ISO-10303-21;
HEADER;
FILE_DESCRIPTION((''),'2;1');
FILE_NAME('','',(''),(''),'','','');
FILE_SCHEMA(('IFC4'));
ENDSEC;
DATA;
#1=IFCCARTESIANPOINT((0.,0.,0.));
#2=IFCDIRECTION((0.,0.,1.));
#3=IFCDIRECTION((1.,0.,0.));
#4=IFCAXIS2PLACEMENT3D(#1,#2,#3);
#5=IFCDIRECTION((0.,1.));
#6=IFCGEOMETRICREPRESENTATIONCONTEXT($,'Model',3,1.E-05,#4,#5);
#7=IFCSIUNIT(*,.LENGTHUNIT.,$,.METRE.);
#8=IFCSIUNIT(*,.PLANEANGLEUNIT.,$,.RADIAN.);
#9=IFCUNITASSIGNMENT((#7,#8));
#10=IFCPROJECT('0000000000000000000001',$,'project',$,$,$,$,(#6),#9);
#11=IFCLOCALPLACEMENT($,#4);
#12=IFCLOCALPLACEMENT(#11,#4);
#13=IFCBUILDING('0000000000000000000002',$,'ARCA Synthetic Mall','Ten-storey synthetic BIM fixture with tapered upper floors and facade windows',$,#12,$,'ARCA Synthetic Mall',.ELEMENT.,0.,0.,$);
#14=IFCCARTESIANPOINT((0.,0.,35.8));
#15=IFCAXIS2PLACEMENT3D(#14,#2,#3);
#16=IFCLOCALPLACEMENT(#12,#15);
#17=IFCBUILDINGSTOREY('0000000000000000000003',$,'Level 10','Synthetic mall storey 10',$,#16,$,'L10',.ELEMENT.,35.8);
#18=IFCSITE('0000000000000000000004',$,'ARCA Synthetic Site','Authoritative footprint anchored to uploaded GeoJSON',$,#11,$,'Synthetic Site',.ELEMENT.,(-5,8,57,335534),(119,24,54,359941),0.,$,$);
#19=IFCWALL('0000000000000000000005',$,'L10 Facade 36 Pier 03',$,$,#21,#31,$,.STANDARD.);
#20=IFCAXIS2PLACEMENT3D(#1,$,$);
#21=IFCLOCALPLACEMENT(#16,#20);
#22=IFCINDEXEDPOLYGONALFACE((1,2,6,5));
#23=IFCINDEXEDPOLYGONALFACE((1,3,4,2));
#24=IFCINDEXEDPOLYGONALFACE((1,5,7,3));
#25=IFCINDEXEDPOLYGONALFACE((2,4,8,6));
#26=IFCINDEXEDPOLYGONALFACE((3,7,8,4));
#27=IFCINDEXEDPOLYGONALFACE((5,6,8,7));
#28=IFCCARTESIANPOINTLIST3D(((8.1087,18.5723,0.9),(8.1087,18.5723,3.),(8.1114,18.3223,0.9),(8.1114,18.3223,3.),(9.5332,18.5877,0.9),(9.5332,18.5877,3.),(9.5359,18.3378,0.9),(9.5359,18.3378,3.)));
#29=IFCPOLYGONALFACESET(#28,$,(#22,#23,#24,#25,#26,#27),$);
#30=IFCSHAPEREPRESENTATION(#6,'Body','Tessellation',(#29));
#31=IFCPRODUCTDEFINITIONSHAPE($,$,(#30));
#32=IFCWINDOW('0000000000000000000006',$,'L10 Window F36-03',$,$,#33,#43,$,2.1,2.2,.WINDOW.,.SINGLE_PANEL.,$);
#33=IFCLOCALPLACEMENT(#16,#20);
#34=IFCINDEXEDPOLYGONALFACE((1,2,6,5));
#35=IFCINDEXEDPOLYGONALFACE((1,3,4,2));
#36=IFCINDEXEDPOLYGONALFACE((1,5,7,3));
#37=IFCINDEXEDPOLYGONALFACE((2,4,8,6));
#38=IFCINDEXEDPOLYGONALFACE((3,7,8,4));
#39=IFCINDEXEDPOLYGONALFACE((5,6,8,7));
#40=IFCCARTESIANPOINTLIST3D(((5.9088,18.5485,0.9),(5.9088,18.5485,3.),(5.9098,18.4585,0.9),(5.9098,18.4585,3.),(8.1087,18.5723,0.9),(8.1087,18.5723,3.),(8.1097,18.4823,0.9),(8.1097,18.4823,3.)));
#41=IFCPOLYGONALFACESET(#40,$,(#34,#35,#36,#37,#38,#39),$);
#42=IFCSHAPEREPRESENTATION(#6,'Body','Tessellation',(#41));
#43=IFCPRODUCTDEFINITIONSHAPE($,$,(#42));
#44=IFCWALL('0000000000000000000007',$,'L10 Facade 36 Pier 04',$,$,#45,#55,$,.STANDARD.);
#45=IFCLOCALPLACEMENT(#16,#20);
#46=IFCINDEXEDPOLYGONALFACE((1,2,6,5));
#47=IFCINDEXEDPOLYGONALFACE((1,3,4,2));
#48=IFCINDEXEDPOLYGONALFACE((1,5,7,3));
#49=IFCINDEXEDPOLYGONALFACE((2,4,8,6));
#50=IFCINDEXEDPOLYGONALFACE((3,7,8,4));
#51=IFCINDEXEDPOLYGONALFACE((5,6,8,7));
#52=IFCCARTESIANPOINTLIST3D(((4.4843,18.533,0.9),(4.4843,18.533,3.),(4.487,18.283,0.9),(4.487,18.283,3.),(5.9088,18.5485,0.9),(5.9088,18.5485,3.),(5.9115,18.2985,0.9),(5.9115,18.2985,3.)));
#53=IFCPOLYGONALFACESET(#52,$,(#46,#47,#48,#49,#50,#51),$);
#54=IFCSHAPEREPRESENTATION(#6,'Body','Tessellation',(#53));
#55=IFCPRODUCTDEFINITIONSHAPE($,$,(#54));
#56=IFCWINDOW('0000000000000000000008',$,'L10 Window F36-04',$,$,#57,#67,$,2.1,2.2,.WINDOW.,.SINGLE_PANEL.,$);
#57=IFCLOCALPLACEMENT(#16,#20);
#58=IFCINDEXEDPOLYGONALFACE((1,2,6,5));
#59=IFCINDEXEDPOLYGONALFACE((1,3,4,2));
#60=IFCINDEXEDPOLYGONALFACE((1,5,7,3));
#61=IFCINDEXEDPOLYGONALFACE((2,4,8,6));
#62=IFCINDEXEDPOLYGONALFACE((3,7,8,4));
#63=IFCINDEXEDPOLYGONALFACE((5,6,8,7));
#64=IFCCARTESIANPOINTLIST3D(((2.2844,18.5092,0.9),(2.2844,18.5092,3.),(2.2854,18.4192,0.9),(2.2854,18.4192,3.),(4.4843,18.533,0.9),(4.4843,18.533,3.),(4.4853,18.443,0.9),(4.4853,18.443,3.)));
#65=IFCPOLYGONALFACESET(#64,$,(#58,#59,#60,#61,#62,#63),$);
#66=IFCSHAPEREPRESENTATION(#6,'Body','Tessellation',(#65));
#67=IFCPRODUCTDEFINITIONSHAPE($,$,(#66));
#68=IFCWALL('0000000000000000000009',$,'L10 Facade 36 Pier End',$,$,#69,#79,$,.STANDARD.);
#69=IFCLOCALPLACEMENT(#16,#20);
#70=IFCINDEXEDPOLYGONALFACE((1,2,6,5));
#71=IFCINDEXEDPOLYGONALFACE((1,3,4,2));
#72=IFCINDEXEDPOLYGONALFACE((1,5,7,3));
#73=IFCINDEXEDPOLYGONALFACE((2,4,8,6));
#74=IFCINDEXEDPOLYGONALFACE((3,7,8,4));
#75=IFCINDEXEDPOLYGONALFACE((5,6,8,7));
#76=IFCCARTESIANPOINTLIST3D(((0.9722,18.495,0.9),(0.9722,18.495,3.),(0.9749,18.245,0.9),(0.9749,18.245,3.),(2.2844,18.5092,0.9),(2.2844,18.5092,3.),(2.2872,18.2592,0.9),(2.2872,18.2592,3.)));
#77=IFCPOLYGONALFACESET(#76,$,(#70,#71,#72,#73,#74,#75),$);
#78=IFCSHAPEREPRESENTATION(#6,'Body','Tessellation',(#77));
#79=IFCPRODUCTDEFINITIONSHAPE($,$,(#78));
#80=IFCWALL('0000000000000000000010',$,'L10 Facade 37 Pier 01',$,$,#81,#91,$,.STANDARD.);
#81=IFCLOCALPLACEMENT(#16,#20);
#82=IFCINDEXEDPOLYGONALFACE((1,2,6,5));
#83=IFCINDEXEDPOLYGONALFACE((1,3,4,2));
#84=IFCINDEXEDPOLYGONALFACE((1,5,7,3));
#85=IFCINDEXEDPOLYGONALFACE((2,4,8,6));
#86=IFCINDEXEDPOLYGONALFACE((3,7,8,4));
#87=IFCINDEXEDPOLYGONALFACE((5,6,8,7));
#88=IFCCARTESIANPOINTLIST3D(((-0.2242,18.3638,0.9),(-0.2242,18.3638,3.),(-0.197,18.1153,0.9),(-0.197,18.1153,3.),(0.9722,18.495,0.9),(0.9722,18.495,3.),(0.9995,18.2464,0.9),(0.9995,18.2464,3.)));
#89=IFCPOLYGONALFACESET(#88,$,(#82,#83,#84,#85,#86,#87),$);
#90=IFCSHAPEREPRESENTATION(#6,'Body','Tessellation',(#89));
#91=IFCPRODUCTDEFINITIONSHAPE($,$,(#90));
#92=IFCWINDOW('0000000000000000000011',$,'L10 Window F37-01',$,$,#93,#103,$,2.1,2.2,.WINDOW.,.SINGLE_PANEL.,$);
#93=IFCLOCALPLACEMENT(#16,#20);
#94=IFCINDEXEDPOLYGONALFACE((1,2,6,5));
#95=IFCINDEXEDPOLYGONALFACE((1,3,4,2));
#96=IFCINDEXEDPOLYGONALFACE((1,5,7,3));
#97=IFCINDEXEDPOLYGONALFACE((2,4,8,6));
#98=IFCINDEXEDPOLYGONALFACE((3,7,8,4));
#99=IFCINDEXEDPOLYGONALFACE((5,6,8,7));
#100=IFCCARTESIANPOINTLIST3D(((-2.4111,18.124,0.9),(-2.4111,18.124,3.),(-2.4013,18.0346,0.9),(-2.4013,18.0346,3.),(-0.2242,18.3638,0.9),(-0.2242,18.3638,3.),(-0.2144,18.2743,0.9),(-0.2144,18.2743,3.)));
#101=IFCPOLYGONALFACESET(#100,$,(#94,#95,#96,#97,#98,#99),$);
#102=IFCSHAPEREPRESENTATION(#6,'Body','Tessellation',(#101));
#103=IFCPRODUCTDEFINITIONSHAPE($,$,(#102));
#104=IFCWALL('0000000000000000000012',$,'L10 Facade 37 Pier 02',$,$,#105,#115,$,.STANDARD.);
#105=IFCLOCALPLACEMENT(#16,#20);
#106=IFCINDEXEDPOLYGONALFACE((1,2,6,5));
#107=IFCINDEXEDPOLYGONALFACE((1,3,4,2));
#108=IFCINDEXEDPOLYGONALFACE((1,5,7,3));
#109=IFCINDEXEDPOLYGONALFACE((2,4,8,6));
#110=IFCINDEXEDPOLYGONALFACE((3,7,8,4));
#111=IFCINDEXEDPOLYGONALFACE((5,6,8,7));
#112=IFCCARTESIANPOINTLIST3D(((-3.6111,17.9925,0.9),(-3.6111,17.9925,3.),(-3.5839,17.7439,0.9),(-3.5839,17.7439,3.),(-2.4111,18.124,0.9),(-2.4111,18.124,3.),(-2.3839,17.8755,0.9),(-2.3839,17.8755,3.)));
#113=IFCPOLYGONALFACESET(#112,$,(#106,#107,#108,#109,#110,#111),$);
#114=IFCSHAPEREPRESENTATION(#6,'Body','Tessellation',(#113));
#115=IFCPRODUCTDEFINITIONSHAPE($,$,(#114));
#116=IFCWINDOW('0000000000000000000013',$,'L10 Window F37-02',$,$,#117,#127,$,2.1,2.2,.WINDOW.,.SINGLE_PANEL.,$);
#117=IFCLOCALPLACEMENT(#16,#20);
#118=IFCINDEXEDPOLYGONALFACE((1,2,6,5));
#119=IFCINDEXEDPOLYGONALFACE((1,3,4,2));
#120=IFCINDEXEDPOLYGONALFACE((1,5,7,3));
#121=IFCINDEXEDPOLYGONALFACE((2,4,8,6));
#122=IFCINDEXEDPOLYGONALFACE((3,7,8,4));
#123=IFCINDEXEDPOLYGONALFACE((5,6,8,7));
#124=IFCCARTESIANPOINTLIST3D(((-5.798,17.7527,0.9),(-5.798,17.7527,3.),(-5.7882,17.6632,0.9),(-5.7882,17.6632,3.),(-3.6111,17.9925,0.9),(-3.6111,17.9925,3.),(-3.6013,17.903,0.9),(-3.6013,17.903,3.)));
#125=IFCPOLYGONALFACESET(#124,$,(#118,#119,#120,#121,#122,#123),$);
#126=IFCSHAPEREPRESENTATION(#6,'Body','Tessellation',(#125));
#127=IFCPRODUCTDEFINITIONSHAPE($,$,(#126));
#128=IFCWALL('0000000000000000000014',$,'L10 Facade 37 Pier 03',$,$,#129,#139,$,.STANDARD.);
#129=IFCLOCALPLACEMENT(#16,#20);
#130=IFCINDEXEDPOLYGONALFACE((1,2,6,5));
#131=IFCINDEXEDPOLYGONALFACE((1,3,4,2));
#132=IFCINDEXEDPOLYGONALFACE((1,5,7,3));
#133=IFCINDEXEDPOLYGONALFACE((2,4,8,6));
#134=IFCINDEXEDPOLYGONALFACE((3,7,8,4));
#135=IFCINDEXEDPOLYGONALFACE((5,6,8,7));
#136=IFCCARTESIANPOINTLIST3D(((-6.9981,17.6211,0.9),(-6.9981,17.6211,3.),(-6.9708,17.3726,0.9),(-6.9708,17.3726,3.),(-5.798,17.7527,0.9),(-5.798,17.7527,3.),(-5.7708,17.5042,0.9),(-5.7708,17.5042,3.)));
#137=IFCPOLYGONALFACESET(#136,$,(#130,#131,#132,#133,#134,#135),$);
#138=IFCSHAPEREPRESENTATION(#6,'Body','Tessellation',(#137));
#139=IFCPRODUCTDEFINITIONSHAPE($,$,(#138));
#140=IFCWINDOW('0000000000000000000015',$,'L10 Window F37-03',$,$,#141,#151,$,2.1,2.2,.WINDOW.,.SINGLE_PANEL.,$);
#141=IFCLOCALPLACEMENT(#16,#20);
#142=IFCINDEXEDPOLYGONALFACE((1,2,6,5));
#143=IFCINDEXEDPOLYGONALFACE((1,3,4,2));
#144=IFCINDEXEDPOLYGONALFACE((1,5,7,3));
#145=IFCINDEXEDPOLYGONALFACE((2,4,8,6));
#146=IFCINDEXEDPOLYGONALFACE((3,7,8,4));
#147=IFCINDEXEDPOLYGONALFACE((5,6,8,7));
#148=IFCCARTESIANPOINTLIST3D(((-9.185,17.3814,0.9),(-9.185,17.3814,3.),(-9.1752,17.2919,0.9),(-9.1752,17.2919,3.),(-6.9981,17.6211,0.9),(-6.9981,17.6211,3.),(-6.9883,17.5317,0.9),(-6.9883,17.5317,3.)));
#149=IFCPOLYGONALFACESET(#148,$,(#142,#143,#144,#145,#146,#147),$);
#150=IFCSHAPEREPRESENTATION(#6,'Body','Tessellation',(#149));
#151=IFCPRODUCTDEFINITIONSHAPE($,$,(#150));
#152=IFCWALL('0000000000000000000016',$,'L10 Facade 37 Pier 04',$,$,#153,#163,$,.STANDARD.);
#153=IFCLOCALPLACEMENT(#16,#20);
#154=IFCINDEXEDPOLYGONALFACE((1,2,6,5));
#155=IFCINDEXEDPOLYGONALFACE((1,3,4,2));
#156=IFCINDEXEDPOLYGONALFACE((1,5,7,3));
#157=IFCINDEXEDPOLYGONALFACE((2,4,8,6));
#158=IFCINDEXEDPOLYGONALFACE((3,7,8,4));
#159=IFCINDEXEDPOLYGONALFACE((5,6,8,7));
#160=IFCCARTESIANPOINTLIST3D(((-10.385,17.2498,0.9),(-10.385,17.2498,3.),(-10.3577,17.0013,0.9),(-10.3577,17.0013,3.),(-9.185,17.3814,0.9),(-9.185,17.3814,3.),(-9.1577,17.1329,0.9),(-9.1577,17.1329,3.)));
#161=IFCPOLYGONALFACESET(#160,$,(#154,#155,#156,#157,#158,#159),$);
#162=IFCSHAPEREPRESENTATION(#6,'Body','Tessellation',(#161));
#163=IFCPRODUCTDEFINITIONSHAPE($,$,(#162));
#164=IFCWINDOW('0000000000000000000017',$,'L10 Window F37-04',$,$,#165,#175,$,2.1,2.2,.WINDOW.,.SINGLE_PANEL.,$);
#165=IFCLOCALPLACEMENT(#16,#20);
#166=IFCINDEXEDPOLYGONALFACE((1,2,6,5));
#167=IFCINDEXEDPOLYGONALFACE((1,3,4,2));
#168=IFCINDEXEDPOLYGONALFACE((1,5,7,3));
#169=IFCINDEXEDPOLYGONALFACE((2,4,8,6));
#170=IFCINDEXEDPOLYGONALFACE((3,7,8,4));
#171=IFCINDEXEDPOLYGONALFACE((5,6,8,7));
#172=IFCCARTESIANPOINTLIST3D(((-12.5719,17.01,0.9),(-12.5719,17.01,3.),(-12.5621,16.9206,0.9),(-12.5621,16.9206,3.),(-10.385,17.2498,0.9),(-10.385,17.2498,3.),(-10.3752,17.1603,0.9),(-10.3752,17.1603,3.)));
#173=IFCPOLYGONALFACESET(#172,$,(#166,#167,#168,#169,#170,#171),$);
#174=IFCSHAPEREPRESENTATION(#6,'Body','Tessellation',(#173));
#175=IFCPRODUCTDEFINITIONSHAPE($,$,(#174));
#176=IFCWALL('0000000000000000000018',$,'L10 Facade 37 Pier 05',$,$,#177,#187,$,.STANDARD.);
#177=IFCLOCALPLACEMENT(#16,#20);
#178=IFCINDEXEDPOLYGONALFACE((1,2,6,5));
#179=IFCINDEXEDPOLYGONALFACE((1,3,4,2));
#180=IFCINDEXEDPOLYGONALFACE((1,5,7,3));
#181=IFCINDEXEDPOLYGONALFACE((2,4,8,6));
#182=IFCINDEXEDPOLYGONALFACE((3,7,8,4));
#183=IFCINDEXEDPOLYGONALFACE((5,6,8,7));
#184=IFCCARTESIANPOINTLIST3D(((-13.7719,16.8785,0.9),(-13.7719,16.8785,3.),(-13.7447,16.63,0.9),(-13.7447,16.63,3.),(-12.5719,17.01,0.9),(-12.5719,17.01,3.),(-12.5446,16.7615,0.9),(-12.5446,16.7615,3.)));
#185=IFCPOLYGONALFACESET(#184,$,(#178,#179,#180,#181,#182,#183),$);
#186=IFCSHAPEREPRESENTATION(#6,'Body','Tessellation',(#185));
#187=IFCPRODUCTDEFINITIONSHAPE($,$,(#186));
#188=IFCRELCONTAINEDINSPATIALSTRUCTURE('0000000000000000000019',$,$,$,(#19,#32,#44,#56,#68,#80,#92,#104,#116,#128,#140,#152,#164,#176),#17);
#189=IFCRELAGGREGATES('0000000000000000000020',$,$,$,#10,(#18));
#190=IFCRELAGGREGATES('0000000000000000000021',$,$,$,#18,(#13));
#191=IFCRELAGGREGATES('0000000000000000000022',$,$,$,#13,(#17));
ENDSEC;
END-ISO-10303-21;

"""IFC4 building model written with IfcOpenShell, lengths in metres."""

from ifc_helpers import new_model, si_unit, direction, frame, origin_with_axes, place, context, project, spatial, polyline, outline, extrude, element, save


model = new_model("IFC4")

# Units and contexts
model_context = context("Model", 3, precision=1e-05, world=origin_with_axes(), true_north=direction((0.0, 1.0)))
ifc_project = project(units=[si_unit("LENGTHUNIT", "METRE"), si_unit("PLANEANGLEUNIT", "RADIAN")], contexts=[model_context])

# Site, building, storey
site_placement = place(None, origin_with_axes())
site = spatial("IfcSite", under=ifc_project, at=site_placement, Name="ARCA Synthetic Site", Description="Authoritative footprint anchored to uploaded GeoJSON", LongName="Synthetic Site", CompositionType="ELEMENT", RefLatitude=(-5, 8, 57, 335534), RefLongitude=(119, 24, 54, 359941), RefElevation=0.0)
building_placement = place(site_placement, origin_with_axes())
building = spatial("IfcBuilding", under=site, at=building_placement, Name="ARCA Synthetic Mall", Description="Ten-storey synthetic BIM fixture with tapered upper floors and facade windows", LongName="ARCA Synthetic Mall", CompositionType="ELEMENT", ElevationOfRefHeight=0.0, ElevationOfTerrain=0.0)
storey_placement = place(building_placement, frame((0.0, 0.0, 35.8), z_axis=(0.0, 0.0, 1.0), x_axis=(1.0, 0.0, 0.0)))
storey = spatial("IfcBuildingStorey", under=building, at=storey_placement, Name="Level 10", Description="Synthetic mall storey 10", LongName="L10", CompositionType="ELEMENT", Elevation=35.8)

# Wall
wall_1_placement = place(storey_placement, frame((0.0, 0.0, 0.9), z_axis=(0.0, 0.0, 1.0), x_axis=(1.0, 0.0, 0.0)))
element("IfcWall", 1, at=wall_1_placement, inside=storey, Name="L10 Facade 36 Pier 03", PredefinedType="STANDARD", context=model_context, shape_type="SweptSolid", body=[
    extrude(outline(polyline([(9.5332, 18.5877), (8.1087, 18.5723), (8.1114, 18.3223), (9.5359, 18.3378), (9.5332, 18.5877)])), origin_with_axes(), (0.0, 0.0, 1.0), 2.1),
])

# Window
window_1_placement = place(storey_placement, frame((0.0, 0.0, 0.9), z_axis=(0.0, 0.0, 1.0), x_axis=(1.0, 0.0, 0.0)))
element("IfcWindow", 2, at=window_1_placement, inside=storey, Name="L10 Window F36-03", OverallHeight=2.1, OverallWidth=2.2, PartitioningType="SINGLE_PANEL", PredefinedType="WINDOW", context=model_context, shape_type="SweptSolid", body=[
    extrude(outline(polyline([(8.1087, 18.5723), (5.9088, 18.5485), (5.9098, 18.4585), (8.1097, 18.4823), (8.1087, 18.5723)])), origin_with_axes(), (0.0, 0.0, 1.0), 2.1),
])

# Wall
wall_2_placement = place(storey_placement, frame((0.0, 0.0, 0.9), z_axis=(0.0, 0.0, 1.0), x_axis=(1.0, 0.0, 0.0)))
element("IfcWall", 3, at=wall_2_placement, inside=storey, Name="L10 Facade 36 Pier 04", PredefinedType="STANDARD", context=model_context, shape_type="SweptSolid", body=[
    extrude(outline(polyline([(5.9088, 18.5485), (4.4843, 18.533), (4.487, 18.283), (5.9115, 18.2985), (5.9088, 18.5485)])), origin_with_axes(), (0.0, 0.0, 1.0), 2.1),
])

# Window
window_2_placement = place(storey_placement, frame((0.0, 0.0, 0.9), z_axis=(0.0, 0.0, 1.0), x_axis=(1.0, 0.0, 0.0)))
element("IfcWindow", 4, at=window_2_placement, inside=storey, Name="L10 Window F36-04", OverallHeight=2.1, OverallWidth=2.2, PartitioningType="SINGLE_PANEL", PredefinedType="WINDOW", context=model_context, shape_type="SweptSolid", body=[
    extrude(outline(polyline([(4.4843, 18.533), (2.2844, 18.5092), (2.2854, 18.4192), (4.4853, 18.443), (4.4843, 18.533)])), origin_with_axes(), (0.0, 0.0, 1.0), 2.1),
])

# Walls
wall_3_placement = place(storey_placement, frame((0.0, 0.0, 0.9), z_axis=(0.0, 0.0, 1.0), x_axis=(1.0, 0.0, 0.0)))
element("IfcWall", 5, at=wall_3_placement, inside=storey, Name="L10 Facade 36 Pier End", PredefinedType="STANDARD", context=model_context, shape_type="SweptSolid", body=[
    extrude(outline(polyline([(2.2844, 18.5092), (0.9722, 18.495), (0.9749, 18.245), (2.2872, 18.2592), (2.2844, 18.5092)])), origin_with_axes(), (0.0, 0.0, 1.0), 2.1),
])
wall_4_placement = place(storey_placement, frame((0.0, 0.0, 0.9), z_axis=(0.0, 0.0, 1.0), x_axis=(1.0, 0.0, 0.0)))
element("IfcWall", 6, at=wall_4_placement, inside=storey, Name="L10 Facade 37 Pier 01", PredefinedType="STANDARD", context=model_context, shape_type="SweptSolid", body=[
    extrude(outline(polyline([(0.9722, 18.495), (-0.2242, 18.3638), (-0.197, 18.1153), (0.9995, 18.2464), (0.9722, 18.495)])), origin_with_axes(), (0.0, 0.0, 1.0), 2.1),
])

# Window
window_3_placement = place(storey_placement, frame((0.0, 0.0, 0.9), z_axis=(0.0, 0.0, 1.0), x_axis=(1.0, 0.0, 0.0)))
element("IfcWindow", 7, at=window_3_placement, inside=storey, Name="L10 Window F37-01", OverallHeight=2.1, OverallWidth=2.2, PartitioningType="SINGLE_PANEL", PredefinedType="WINDOW", context=model_context, shape_type="SweptSolid", body=[
    extrude(outline(polyline([(-0.2242, 18.3638), (-2.4111, 18.124), (-2.4013, 18.0346), (-0.2144, 18.2743), (-0.2242, 18.3638)])), origin_with_axes(), (0.0, 0.0, 1.0), 2.1),
])

# Wall
wall_5_placement = place(storey_placement, frame((0.0, 0.0, 0.9), z_axis=(0.0, 0.0, 1.0), x_axis=(1.0, 0.0, 0.0)))
element("IfcWall", 8, at=wall_5_placement, inside=storey, Name="L10 Facade 37 Pier 02", PredefinedType="STANDARD", context=model_context, shape_type="SweptSolid", body=[
    extrude(outline(polyline([(-2.4111, 18.124), (-3.6111, 17.9925), (-3.5839, 17.7439), (-2.3839, 17.8755), (-2.4111, 18.124)])), origin_with_axes(), (0.0, 0.0, 1.0), 2.1),
])

# Window
window_4_placement = place(storey_placement, frame((0.0, 0.0, 0.9), z_axis=(0.0, 0.0, 1.0), x_axis=(1.0, 0.0, 0.0)))
element("IfcWindow", 9, at=window_4_placement, inside=storey, Name="L10 Window F37-02", OverallHeight=2.1, OverallWidth=2.2, PartitioningType="SINGLE_PANEL", PredefinedType="WINDOW", context=model_context, shape_type="SweptSolid", body=[
    extrude(outline(polyline([(-3.6111, 17.9925), (-5.798, 17.7527), (-5.7882, 17.6632), (-3.6013, 17.903), (-3.6111, 17.9925)])), origin_with_axes(), (0.0, 0.0, 1.0), 2.1),
])

# Wall
wall_6_placement = place(storey_placement, frame((0.0, 0.0, 0.9), z_axis=(0.0, 0.0, 1.0), x_axis=(1.0, 0.0, 0.0)))
element("IfcWall", 10, at=wall_6_placement, inside=storey, Name="L10 Facade 37 Pier 03", PredefinedType="STANDARD", context=model_context, shape_type="SweptSolid", body=[
    extrude(outline(polyline([(-5.798, 17.7527), (-6.9981, 17.6211), (-6.9708, 17.3726), (-5.7708, 17.5042), (-5.798, 17.7527)])), origin_with_axes(), (0.0, 0.0, 1.0), 2.1),
])

# Window
window_5_placement = place(storey_placement, frame((0.0, 0.0, 0.9), z_axis=(0.0, 0.0, 1.0), x_axis=(1.0, 0.0, 0.0)))
element("IfcWindow", 11, at=window_5_placement, inside=storey, Name="L10 Window F37-03", OverallHeight=2.1, OverallWidth=2.2, PartitioningType="SINGLE_PANEL", PredefinedType="WINDOW", context=model_context, shape_type="SweptSolid", body=[
    extrude(outline(polyline([(-6.9981, 17.6211), (-9.185, 17.3814), (-9.1752, 17.2919), (-6.9883, 17.5317), (-6.9981, 17.6211)])), origin_with_axes(), (0.0, 0.0, 1.0), 2.1),
])

# Wall
wall_7_placement = place(storey_placement, frame((0.0, 0.0, 0.9), z_axis=(0.0, 0.0, 1.0), x_axis=(1.0, 0.0, 0.0)))
element("IfcWall", 12, at=wall_7_placement, inside=storey, Name="L10 Facade 37 Pier 04", PredefinedType="STANDARD", context=model_context, shape_type="SweptSolid", body=[
    extrude(outline(polyline([(-9.185, 17.3814), (-10.385, 17.2498), (-10.3577, 17.0013), (-9.1577, 17.1329), (-9.185, 17.3814)])), origin_with_axes(), (0.0, 0.0, 1.0), 2.1),
])

# Window
window_6_placement = place(storey_placement, frame((0.0, 0.0, 0.9), z_axis=(0.0, 0.0, 1.0), x_axis=(1.0, 0.0, 0.0)))
element("IfcWindow", 13, at=window_6_placement, inside=storey, Name="L10 Window F37-04", OverallHeight=2.1, OverallWidth=2.2, PartitioningType="SINGLE_PANEL", PredefinedType="WINDOW", context=model_context, shape_type="SweptSolid", body=[
    extrude(outline(polyline([(-10.385, 17.2498), (-12.5719, 17.01), (-12.5621, 16.9206), (-10.3752, 17.1603), (-10.385, 17.2498)])), origin_with_axes(), (0.0, 0.0, 1.0), 2.1),
])

# Wall
wall_8_placement = place(storey_placement, frame((0.0, 0.0, 0.9), z_axis=(0.0, 0.0, 1.0), x_axis=(1.0, 0.0, 0.0)))
element("IfcWall", 14, at=wall_8_placement, inside=storey, Name="L10 Facade 37 Pier 05", PredefinedType="STANDARD", context=model_context, shape_type="SweptSolid", body=[
    extrude(outline(polyline([(-12.5719, 17.01), (-13.7719, 16.8785), (-13.7447, 16.63), (-12.5446, 16.7615), (-12.5719, 17.01)])), origin_with_axes(), (0.0, 0.0, 1.0), 2.1),
])

save(model, "model.ifc")
